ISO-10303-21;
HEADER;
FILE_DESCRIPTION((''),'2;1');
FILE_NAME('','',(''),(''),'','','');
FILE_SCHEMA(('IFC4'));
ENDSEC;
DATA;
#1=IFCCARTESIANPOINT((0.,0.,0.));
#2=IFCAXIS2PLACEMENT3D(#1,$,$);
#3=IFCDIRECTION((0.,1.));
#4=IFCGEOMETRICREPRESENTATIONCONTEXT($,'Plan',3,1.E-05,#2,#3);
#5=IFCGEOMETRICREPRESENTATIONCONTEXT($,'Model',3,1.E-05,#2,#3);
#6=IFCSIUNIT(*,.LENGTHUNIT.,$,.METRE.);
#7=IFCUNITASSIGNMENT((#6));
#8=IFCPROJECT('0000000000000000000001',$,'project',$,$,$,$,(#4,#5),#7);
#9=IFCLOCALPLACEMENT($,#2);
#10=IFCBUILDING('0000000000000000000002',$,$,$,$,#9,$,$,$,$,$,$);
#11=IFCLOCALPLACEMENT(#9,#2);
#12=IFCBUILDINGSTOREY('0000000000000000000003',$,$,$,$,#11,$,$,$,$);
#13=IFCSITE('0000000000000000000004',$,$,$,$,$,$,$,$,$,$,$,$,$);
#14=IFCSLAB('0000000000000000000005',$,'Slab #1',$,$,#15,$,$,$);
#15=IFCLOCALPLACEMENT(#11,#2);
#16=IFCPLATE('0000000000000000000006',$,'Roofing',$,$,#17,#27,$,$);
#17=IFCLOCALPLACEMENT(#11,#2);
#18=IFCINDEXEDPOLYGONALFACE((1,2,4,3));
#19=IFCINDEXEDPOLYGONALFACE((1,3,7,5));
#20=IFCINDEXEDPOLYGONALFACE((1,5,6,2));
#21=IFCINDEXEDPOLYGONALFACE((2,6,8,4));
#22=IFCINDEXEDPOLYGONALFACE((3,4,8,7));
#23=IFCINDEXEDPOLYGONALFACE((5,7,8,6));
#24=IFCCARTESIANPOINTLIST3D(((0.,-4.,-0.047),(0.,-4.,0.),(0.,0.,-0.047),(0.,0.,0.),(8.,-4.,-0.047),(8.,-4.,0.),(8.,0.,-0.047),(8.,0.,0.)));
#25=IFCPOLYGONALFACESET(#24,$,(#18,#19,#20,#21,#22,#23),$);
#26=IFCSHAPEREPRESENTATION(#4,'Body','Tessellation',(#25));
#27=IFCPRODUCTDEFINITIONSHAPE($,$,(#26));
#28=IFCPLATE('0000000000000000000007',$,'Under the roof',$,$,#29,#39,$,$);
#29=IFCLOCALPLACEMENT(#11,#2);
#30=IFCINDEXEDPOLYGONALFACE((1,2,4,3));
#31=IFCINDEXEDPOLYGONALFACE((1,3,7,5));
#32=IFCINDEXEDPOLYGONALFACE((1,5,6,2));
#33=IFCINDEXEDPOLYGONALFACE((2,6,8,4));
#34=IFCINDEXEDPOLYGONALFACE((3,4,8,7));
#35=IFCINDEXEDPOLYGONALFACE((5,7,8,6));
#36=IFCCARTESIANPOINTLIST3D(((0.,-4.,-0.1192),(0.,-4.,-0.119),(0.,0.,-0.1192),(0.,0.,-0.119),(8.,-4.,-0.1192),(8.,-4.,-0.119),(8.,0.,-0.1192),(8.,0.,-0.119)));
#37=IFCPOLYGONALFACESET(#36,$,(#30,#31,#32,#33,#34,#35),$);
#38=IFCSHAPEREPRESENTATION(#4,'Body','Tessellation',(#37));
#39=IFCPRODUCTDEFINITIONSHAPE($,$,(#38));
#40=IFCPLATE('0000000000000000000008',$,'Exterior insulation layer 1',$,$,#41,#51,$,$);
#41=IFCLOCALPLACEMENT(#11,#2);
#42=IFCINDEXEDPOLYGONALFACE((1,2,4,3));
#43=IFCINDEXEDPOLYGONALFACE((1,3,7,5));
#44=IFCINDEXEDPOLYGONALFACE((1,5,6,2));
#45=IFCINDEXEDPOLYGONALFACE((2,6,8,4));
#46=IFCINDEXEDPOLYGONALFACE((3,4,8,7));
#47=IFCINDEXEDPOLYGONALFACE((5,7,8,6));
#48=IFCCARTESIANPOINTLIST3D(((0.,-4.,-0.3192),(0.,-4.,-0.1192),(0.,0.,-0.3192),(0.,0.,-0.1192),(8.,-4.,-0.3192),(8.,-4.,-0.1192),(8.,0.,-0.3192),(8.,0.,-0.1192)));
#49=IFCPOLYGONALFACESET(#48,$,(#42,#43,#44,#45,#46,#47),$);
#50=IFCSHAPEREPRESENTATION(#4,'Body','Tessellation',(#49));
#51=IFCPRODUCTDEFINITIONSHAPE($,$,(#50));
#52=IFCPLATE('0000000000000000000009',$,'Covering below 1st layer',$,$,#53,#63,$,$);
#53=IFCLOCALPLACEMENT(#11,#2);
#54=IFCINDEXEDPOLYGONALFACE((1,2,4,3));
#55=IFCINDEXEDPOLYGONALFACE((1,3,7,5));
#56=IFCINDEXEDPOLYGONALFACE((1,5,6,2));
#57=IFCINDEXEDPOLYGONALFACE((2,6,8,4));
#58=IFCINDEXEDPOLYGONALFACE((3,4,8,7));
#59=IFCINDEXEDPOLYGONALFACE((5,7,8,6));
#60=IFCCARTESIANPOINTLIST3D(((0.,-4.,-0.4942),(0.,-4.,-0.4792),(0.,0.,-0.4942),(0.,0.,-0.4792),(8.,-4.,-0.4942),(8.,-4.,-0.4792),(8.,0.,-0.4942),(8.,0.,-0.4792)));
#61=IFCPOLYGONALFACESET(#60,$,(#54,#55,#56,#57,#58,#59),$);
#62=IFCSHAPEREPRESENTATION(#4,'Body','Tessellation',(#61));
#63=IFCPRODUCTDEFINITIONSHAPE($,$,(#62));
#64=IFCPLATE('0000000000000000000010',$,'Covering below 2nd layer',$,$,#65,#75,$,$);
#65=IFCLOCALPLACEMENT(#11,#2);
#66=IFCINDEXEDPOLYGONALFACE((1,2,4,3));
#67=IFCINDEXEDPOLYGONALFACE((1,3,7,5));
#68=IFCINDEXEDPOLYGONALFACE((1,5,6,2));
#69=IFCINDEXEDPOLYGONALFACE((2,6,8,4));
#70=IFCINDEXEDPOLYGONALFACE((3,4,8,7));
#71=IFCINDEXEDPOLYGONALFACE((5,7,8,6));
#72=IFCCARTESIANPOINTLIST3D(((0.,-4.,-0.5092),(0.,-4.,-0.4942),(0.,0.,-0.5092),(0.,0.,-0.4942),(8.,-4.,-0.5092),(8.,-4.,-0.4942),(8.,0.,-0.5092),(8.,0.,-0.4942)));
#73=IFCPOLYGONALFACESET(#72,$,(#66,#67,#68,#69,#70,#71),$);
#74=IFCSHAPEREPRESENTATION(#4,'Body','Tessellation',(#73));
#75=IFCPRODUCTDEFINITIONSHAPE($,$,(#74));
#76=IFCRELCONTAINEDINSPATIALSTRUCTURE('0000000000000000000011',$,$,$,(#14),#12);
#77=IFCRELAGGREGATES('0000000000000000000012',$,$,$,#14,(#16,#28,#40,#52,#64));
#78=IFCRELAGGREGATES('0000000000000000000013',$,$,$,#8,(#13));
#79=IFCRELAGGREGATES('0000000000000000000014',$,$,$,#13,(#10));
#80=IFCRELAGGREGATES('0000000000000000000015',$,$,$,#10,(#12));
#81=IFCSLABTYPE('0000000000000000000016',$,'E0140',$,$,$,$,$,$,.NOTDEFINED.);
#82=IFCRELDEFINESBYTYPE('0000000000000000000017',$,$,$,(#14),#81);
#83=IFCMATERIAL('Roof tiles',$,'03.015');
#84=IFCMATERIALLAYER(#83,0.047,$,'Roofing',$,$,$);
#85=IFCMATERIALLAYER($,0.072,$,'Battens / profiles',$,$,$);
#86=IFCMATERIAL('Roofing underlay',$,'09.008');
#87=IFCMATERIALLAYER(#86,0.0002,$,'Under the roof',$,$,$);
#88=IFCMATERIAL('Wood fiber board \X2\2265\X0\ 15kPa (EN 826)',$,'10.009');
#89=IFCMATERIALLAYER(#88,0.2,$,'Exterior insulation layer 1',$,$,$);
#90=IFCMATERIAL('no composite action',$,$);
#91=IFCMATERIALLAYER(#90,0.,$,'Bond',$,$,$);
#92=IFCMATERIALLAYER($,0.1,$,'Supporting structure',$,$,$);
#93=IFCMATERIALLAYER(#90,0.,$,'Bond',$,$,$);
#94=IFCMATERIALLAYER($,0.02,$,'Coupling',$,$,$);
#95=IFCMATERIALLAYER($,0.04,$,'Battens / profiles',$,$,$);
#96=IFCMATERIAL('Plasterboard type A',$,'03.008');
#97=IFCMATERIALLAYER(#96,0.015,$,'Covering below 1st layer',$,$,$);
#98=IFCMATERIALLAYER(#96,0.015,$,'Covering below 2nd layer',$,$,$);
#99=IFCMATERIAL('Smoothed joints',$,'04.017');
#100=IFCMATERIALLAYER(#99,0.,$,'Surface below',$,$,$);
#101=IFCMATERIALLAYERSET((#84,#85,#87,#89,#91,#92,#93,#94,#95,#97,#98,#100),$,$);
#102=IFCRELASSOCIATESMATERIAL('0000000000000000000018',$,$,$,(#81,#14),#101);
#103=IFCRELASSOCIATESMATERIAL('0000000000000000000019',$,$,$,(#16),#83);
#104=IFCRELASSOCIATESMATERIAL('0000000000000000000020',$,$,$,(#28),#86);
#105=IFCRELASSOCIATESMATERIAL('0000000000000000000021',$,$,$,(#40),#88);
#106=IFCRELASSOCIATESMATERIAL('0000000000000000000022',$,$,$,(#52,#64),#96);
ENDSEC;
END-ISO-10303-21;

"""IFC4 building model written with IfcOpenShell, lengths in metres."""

from ifc_helpers import new_model, si_unit, direction, frame, frame_2d, origin, origin_with_axes, place, context, project, spatial, rectangle, extrude, material, layer, layer_set, type_object, element, aggregate, save


model = new_model("IFC4")

# Units and contexts
plan_context = context("Plan", 3, precision=1e-05, world=origin(), true_north=direction((0.0, 1.0)))
model_context = context("Model", 3, precision=1e-05, world=origin(), true_north=direction((0.0, 1.0)))
ifc_project = project(units=[si_unit("LENGTHUNIT", "METRE")], contexts=[plan_context, model_context])

# Site, building, storey
site = spatial("IfcSite", under=ifc_project)
building_placement = place(None, origin())
building = spatial("IfcBuilding", under=site, at=building_placement)
storey_placement = place(building_placement, origin())
storey = spatial("IfcBuildingStorey", under=building, at=storey_placement)

# Slab, plates
ifc_material_1 = material(Name="Roof tiles", Category="03.015")
ifc_layer_1 = layer(ifc_material_1, 0.047, Name="Roofing")
ifc_layer_2 = layer(None, 0.072, Name="Battens / profiles")
ifc_material_2 = material(Name="Roofing underlay", Category="09.008")
ifc_layer_3 = layer(ifc_material_2, 0.0002, Name="Under the roof")
ifc_material_3 = material(Name="Wood fiber board ≥ 15kPa (EN 826)", Category="10.009")
ifc_layer_4 = layer(ifc_material_3, 0.2, Name="Exterior insulation layer 1")
ifc_material_4 = material(Name="no composite action")
ifc_layer_5 = layer(ifc_material_4, 0.0, Name="Bond")
ifc_layer_6 = layer(None, 0.1, Name="Supporting structure")
ifc_layer_7 = layer(ifc_material_4, 0.0, Name="Bond")
ifc_layer_8 = layer(None, 0.02, Name="Coupling")
ifc_layer_9 = layer(None, 0.04, Name="Battens / profiles")
ifc_material_5 = material(Name="Plasterboard type A", Category="03.008")
ifc_layer_10 = layer(ifc_material_5, 0.015, Name="Covering below 1st layer")
ifc_layer_11 = layer(ifc_material_5, 0.015, Name="Covering below 2nd layer")
ifc_material_6 = material(Name="Smoothed joints", Category="04.017")
ifc_layer_12 = layer(ifc_material_6, 0.0, Name="Surface below")
ifc_layer_set = layer_set([ifc_layer_1, ifc_layer_2, ifc_layer_3, ifc_layer_4, ifc_layer_5, ifc_layer_6, ifc_layer_7, ifc_layer_8, ifc_layer_9, ifc_layer_10, ifc_layer_11, ifc_layer_12])
slab_type = type_object("IfcSlabType", Name="E0140", PredefinedType="NOTDEFINED", material=ifc_layer_set)
slab_placement = place(None, frame((0.0, 0.0, 0.0), z_axis=(0.0, 0.0, -1.0), x_axis=(1.0, 0.0, 0.0)))
slab = element("IfcSlab", 1, at=slab_placement, inside=storey, type_object=slab_type, material=ifc_layer_set, Name="Slab #1")
plate_1_placement = place(slab_placement, origin())
plate_1 = element("IfcPlate", 2, at=plate_1_placement, material=ifc_material_1, Name="Roofing", context=plan_context, shape_type="SweptSolid", body=[
    extrude(rectangle(XDim=8.0, YDim=4.0, at=frame_2d((4.0, 2.0), x_axis=(1.0, 0.0))), origin_with_axes(), (0.0, 0.0, 1.0), 0.047),
])
plate_2_placement = place(slab_placement, origin())
plate_2 = element("IfcPlate", 3, at=plate_2_placement, material=ifc_material_2, Name="Under the roof", context=plan_context, shape_type="SweptSolid", body=[
    extrude(rectangle(XDim=8.0, YDim=4.0, at=frame_2d((4.0, 2.0), x_axis=(1.0, 0.0))), frame((0.0, 0.0, 0.119), z_axis=(0.0, 0.0, 1.0), x_axis=(1.0, 0.0, 0.0)), (0.0, 0.0, 1.0), 0.0002),
])
plate_3_placement = place(slab_placement, origin())
plate_3 = element("IfcPlate", 4, at=plate_3_placement, material=ifc_material_3, Name="Exterior insulation layer 1", context=plan_context, shape_type="SweptSolid", body=[
    extrude(rectangle(XDim=8.0, YDim=4.0, at=frame_2d((4.0, 2.0), x_axis=(1.0, 0.0))), frame((0.0, 0.0, 0.1192), z_axis=(0.0, 0.0, 1.0), x_axis=(1.0, 0.0, 0.0)), (0.0, 0.0, 1.0), 0.2),
])
plate_4_placement = place(slab_placement, origin())
plate_4 = element("IfcPlate", 5, at=plate_4_placement, material=ifc_material_5, Name="Covering below 1st layer", context=plan_context, shape_type="SweptSolid", body=[
    extrude(rectangle(XDim=8.0, YDim=4.0, at=frame_2d((4.0, 2.0), x_axis=(1.0, 0.0))), frame((0.0, 0.0, 0.4792), z_axis=(0.0, 0.0, 1.0), x_axis=(1.0, 0.0, 0.0)), (0.0, 0.0, 1.0), 0.015),
])
plate_5_placement = place(slab_placement, origin())
plate_5 = element("IfcPlate", 6, at=plate_5_placement, material=ifc_material_5, Name="Covering below 2nd layer", context=plan_context, shape_type="SweptSolid", body=[
    extrude(rectangle(XDim=8.0, YDim=4.0, at=frame_2d((4.0, 2.0), x_axis=(1.0, 0.0))), frame((0.0, 0.0, 0.4942), z_axis=(0.0, 0.0, 1.0), x_axis=(1.0, 0.0, 0.0)), (0.0, 0.0, 1.0), 0.015),
])
aggregate(slab, [plate_1, plate_2, plate_3, plate_4, plate_5])

save(model, "model.ifc")
